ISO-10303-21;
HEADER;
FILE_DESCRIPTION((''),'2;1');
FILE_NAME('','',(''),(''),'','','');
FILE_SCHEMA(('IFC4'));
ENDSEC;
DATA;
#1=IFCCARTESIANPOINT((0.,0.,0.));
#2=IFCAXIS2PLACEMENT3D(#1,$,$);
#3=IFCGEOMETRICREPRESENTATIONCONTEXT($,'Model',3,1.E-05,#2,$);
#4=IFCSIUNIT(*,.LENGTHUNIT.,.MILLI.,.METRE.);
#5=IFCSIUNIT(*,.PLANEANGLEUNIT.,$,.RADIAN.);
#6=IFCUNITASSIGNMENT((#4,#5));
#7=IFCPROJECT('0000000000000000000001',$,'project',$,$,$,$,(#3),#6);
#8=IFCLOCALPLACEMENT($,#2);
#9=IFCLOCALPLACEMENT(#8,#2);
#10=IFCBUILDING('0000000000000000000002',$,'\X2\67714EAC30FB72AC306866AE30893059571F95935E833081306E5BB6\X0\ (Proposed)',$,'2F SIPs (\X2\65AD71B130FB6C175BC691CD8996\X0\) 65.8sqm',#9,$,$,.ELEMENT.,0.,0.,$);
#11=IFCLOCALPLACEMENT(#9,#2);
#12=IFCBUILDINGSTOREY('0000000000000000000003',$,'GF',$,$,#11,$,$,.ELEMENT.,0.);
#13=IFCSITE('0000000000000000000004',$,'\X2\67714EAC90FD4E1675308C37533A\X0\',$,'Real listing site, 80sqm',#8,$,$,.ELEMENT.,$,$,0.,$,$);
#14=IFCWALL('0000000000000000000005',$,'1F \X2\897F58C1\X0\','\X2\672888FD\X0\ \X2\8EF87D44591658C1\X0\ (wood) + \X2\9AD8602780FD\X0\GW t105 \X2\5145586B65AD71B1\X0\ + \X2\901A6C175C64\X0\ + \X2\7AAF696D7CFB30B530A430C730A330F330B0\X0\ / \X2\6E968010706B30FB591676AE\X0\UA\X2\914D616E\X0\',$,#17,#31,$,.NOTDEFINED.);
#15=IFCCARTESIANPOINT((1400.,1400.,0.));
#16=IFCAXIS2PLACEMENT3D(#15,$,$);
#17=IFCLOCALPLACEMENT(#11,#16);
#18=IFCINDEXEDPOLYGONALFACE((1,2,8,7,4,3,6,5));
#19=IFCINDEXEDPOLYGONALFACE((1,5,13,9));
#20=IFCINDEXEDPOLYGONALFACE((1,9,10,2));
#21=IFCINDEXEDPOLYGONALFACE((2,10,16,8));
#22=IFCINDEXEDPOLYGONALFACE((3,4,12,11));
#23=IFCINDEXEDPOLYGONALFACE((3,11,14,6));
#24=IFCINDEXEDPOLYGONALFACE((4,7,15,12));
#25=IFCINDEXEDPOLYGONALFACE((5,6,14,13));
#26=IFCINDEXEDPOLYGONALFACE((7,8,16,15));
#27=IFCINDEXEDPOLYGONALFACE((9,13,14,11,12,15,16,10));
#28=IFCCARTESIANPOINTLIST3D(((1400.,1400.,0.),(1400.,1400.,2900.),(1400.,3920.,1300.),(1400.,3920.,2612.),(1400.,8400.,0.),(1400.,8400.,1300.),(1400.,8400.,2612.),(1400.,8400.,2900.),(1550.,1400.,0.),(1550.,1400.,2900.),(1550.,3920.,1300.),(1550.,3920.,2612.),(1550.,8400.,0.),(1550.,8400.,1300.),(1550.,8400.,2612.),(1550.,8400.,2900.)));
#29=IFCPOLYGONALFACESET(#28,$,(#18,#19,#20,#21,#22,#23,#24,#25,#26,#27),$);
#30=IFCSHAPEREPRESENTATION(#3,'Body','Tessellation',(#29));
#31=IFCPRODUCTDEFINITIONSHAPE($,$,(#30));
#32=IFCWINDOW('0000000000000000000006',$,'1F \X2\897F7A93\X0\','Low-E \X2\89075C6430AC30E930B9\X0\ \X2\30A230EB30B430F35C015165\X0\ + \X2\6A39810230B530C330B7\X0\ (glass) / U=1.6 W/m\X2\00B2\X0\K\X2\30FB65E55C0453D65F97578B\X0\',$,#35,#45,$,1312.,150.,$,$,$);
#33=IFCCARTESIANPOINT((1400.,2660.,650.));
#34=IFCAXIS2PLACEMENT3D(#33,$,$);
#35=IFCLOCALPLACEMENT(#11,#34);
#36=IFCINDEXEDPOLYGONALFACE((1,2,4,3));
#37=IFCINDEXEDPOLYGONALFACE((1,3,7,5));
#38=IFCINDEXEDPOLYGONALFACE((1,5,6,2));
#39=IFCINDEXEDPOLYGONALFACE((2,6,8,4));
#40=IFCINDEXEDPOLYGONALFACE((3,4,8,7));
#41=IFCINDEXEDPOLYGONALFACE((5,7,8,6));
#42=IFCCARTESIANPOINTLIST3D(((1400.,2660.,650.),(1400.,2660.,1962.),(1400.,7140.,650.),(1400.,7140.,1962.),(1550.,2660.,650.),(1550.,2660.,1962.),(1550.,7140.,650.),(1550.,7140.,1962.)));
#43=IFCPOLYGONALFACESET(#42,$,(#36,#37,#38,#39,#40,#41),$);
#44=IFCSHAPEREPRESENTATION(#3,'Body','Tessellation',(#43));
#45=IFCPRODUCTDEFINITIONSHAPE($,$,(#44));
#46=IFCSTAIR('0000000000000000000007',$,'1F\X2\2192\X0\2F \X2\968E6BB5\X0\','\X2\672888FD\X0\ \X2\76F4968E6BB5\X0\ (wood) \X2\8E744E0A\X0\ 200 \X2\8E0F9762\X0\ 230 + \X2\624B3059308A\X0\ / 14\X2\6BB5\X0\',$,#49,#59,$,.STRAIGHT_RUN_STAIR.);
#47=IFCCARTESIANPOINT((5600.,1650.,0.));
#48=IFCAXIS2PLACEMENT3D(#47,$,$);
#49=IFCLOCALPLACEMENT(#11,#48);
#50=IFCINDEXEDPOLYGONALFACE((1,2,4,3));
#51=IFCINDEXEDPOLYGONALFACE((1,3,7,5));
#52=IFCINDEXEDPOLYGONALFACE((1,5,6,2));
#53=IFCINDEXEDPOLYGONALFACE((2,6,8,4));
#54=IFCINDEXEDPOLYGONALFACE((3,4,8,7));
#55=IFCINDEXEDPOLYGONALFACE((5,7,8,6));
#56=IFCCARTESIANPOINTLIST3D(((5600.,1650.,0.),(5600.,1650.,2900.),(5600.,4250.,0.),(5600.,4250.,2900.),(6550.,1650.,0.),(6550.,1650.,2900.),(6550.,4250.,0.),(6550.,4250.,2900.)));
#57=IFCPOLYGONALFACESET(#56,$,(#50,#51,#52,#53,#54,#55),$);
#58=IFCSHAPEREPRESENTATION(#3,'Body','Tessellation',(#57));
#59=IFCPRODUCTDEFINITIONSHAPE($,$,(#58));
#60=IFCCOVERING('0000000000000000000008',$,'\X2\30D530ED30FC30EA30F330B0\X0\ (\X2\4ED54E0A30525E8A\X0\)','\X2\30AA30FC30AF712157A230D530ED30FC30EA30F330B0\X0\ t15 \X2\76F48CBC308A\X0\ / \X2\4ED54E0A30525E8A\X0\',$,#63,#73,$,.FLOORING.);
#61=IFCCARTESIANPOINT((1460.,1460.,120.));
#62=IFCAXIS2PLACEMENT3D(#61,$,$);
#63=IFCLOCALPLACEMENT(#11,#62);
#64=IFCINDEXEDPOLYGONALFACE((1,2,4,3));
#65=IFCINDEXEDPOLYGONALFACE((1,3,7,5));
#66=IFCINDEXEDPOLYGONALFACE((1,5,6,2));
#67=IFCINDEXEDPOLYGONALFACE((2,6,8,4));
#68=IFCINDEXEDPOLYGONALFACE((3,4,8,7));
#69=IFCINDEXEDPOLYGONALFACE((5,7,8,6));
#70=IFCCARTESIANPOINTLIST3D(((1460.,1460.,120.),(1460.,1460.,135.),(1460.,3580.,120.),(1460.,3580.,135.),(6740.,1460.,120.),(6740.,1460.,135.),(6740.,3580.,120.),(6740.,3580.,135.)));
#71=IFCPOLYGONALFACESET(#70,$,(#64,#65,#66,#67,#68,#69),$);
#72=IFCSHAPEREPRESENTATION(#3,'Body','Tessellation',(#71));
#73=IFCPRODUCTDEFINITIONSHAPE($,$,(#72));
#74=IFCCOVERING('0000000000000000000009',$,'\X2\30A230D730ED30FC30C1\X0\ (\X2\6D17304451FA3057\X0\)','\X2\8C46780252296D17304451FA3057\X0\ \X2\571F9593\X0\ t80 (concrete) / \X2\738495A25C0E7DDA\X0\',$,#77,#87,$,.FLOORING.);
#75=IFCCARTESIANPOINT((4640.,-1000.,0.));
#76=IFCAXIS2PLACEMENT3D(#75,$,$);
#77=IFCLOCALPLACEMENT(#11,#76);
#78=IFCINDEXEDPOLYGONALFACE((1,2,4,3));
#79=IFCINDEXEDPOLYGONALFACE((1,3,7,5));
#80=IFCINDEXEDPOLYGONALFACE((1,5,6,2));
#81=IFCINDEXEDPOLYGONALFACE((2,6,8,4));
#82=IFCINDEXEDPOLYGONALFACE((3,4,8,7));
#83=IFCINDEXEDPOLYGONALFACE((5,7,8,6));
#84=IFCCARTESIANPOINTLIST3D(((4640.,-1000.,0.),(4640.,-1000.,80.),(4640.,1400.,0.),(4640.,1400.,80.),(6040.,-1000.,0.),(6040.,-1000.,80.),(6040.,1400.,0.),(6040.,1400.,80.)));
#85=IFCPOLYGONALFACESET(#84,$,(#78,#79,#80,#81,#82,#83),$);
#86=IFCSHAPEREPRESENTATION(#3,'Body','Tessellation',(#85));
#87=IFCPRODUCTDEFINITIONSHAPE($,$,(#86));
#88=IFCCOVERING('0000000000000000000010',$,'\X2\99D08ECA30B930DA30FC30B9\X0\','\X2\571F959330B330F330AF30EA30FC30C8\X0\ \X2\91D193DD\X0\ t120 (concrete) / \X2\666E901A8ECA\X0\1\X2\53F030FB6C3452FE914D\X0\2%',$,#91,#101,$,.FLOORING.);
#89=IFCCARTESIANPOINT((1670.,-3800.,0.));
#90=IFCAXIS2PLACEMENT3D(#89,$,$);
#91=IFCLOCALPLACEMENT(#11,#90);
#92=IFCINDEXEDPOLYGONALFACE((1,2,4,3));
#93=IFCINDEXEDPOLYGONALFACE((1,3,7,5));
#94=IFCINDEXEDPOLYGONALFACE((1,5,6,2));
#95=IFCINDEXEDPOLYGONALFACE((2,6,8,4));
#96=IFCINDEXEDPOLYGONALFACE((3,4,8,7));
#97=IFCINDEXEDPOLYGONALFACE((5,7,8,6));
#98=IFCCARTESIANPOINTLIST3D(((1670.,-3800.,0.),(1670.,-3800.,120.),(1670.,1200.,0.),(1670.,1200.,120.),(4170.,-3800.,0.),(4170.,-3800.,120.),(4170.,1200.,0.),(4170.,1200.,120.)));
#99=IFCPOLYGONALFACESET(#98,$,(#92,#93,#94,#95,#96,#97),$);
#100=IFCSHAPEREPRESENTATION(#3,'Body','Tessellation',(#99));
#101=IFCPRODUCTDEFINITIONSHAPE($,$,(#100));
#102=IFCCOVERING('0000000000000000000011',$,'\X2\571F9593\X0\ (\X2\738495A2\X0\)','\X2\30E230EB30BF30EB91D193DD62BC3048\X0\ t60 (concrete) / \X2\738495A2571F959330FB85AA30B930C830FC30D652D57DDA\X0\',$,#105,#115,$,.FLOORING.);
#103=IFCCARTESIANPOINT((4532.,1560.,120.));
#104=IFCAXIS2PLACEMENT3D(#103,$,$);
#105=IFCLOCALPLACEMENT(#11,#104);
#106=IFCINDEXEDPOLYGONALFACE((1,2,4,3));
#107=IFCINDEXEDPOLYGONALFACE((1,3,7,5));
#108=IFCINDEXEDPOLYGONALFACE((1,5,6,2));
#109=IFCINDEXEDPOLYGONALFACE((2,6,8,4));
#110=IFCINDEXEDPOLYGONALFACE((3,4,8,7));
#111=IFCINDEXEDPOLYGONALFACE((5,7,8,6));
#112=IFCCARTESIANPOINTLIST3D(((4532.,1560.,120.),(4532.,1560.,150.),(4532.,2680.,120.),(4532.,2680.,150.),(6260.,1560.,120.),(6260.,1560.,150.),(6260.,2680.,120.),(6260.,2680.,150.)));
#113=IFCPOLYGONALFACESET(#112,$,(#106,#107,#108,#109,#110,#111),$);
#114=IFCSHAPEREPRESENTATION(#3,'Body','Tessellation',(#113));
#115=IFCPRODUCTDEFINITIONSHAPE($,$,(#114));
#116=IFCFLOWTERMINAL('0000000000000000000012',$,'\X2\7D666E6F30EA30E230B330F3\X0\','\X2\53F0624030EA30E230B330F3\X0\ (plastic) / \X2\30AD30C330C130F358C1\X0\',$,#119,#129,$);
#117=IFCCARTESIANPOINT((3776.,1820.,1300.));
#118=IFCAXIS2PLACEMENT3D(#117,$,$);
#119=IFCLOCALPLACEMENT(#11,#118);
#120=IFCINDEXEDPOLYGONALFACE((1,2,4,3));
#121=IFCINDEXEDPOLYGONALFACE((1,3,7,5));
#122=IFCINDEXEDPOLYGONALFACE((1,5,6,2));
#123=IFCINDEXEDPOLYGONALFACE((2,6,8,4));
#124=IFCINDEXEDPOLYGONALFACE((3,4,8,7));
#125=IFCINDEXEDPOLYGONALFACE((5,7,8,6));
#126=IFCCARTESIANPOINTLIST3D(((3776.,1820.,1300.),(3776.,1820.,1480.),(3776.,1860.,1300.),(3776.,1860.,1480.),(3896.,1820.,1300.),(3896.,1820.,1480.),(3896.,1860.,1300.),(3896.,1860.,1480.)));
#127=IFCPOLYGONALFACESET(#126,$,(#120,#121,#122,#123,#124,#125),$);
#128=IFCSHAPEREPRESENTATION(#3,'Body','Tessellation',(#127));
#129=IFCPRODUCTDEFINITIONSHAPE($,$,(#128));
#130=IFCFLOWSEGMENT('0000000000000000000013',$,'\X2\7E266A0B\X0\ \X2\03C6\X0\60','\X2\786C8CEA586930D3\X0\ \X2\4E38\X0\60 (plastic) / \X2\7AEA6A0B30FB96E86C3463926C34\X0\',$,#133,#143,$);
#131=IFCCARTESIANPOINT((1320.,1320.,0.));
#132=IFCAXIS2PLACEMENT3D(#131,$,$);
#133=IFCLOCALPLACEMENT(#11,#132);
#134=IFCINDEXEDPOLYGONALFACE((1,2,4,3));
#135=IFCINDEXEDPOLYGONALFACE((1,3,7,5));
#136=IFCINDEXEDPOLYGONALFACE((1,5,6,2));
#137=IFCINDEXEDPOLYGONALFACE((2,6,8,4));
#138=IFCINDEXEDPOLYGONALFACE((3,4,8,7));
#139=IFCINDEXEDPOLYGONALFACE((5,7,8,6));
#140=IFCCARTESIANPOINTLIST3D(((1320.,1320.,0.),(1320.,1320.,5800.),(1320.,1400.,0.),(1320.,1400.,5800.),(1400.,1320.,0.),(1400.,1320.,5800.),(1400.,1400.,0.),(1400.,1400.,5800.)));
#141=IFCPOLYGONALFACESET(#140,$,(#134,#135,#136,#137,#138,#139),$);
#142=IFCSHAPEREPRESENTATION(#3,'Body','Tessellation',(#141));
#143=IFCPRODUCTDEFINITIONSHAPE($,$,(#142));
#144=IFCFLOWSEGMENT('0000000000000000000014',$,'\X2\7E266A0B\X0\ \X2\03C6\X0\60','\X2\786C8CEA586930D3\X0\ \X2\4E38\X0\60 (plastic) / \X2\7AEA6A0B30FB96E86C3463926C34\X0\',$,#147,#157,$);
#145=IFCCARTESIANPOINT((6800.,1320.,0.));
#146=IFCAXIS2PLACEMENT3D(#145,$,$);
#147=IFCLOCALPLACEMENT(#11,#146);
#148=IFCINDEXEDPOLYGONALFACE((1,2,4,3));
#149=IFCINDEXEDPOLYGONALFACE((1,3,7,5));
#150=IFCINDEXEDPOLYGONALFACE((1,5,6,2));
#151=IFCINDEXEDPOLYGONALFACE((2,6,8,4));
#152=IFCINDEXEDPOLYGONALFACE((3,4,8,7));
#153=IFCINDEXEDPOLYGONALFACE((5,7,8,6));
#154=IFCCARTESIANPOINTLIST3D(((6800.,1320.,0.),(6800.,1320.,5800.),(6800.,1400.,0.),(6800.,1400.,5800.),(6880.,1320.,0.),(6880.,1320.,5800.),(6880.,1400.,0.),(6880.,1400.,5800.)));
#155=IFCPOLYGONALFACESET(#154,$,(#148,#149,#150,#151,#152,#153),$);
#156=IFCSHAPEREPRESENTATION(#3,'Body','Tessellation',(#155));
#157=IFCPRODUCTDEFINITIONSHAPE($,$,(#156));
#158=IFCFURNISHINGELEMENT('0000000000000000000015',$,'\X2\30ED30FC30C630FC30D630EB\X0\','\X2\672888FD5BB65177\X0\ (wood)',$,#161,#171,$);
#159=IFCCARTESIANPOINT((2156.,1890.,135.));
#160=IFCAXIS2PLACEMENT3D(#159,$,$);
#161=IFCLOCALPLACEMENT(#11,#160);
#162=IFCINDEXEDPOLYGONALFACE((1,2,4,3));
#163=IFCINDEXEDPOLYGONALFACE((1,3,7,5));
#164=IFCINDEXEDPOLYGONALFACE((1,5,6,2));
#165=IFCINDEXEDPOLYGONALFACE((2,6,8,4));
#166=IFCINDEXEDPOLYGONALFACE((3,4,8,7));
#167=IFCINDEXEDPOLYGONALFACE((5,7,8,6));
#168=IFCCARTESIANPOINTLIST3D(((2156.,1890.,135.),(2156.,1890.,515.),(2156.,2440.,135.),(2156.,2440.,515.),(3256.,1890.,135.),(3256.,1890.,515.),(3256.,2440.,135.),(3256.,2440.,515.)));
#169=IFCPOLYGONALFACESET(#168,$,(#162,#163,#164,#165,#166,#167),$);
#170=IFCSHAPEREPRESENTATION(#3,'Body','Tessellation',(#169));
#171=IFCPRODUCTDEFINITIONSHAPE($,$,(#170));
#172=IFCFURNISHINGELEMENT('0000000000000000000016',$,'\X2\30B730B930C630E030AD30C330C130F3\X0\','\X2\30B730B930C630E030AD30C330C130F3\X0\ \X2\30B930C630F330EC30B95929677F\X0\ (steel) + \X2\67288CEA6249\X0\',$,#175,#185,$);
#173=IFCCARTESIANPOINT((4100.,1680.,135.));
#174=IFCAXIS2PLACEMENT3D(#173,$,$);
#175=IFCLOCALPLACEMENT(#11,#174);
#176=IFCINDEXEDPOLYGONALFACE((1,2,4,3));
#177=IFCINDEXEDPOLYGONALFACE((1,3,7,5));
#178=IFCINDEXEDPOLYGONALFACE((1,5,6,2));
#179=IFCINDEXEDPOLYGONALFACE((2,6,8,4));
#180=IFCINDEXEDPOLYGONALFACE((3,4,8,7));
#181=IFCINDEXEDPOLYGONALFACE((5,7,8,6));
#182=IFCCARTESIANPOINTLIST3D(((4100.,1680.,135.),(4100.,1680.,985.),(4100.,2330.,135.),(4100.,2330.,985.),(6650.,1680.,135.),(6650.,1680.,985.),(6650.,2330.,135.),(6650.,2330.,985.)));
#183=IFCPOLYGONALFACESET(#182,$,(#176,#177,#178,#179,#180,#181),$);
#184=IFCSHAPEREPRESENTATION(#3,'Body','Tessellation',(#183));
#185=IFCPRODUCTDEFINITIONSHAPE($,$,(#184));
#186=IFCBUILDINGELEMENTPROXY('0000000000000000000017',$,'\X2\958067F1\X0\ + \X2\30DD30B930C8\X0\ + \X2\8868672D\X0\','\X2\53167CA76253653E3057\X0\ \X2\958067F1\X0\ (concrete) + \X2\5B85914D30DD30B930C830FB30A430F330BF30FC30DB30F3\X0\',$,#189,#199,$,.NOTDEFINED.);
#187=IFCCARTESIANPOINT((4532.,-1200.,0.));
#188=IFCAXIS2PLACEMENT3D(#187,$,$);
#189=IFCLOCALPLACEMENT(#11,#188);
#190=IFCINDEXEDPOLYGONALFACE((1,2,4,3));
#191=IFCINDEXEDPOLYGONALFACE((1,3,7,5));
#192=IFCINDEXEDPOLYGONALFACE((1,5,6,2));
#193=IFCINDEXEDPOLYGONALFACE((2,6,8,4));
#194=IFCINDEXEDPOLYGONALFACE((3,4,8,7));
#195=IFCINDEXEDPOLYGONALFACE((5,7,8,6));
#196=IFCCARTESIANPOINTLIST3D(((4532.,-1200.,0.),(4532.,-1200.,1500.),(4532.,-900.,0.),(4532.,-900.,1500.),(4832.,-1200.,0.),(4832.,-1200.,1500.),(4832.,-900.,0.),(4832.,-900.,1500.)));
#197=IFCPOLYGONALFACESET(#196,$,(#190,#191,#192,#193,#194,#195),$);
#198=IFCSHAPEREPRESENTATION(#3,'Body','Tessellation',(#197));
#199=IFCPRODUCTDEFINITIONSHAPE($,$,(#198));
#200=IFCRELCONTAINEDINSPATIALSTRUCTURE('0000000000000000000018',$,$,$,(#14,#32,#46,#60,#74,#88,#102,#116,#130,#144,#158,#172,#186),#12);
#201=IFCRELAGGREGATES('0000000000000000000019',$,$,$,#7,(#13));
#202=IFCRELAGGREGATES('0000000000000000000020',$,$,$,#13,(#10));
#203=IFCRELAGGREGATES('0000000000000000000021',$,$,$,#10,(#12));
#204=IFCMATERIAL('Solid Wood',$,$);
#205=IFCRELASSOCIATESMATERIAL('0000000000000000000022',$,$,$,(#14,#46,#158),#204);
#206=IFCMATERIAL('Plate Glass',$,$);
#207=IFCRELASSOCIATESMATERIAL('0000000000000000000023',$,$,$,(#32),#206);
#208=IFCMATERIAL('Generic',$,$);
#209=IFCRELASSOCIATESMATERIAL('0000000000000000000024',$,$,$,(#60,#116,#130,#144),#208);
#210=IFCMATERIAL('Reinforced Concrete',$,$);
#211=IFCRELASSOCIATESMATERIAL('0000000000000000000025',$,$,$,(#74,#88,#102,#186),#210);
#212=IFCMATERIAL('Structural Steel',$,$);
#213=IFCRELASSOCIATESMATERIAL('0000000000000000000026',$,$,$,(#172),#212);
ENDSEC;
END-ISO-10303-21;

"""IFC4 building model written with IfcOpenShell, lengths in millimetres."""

from ifc_helpers import new_model, si_unit, frame, frame_2d, origin, place, context, project, spatial, rectangle, extrude, material, element, fill, save


model = new_model("IFC4")

# Units and contexts
model_context = context("Model", 3, precision=1e-05, world=origin())
ifc_project = project(units=[si_unit("LENGTHUNIT", "METRE", prefix="MILLI"), si_unit("PLANEANGLEUNIT", "RADIAN")], contexts=[model_context])

# Site, building, storey
site_placement = place(None, origin())
site = spatial("IfcSite", under=ifc_project, at=site_placement, Name="東京都世田谷区", ObjectType="Real listing site, 80sqm", CompositionType="ELEMENT", RefElevation=0.0)
building_placement = place(site_placement, origin())
building = spatial("IfcBuilding", under=site, at=building_placement, Name="東京・犬と暮らす土間広めの家 (Proposed)", ObjectType="2F SIPs (断熱・気密重視) 65.8sqm", CompositionType="ELEMENT", ElevationOfRefHeight=0.0, ElevationOfTerrain=0.0)
storey_placement = place(building_placement, origin())
storey = spatial("IfcBuildingStorey", under=building, at=storey_placement, Name="GF", CompositionType="ELEMENT", Elevation=0.0)

# Shared definitions
ifc_material_1 = material(Name="Solid Wood")

# Shared definitions
ifc_material_2 = material(Name="Reinforced Concrete")

# Shared definitions
ifc_material_3 = material(Name="Plate Glass")

# Wall, opening, window
wall_1_placement = place(storey_placement, frame((1400.0, 1400.0, 0.0)))
wall_1 = element("IfcWall", 1, at=wall_1_placement, inside=storey, material=ifc_material_1, Name="1F 西壁", Description="木製 軸組外壁 (wood) + 高性能GW t105 充填断熱 + 通気層 + 窯業系サイディング / 準耐火・外皮UA配慮", PredefinedType="NOTDEFINED", context=model_context, shape_type="SweptSolid", body=[
    extrude(rectangle(XDim=150.0, YDim=7000.0, at=frame_2d((75.0, 3500.0))), frame((1400.0, 1400.0, 0.0)), (0.0, 0.0, 1.0), 2900.0),
])
opening_1_placement = place(storey_placement, frame((1400.0, 2660.0, 650.0)))
opening_1 = element("IfcOpeningElement", 2, at=opening_1_placement, cuts=wall_1, PredefinedType="NOTDEFINED", context=model_context, shape_type="SweptSolid", body=[
    extrude(rectangle(XDim=150.0, YDim=4480.0, at=frame_2d((75.0, 2240.0))), frame((1400.0, 2660.0, 650.0)), (0.0, 0.0, 1.0), 1312.0),
])
window_1_placement = place(storey_placement, frame((1400.0, 2660.0, 650.0)))
window_1 = element("IfcWindow", 3, at=window_1_placement, inside=storey, material=ifc_material_3, Name="1F 西窓", Description="Low-E 複層ガラス アルゴン封入 + 樹脂サッシ (glass) / U=1.6 W/m²K・日射取得型", OverallHeight=1312.0, OverallWidth=150.0, context=model_context, shape_type="SweptSolid", body=[
    extrude(rectangle(XDim=150.0, YDim=4480.0, at=frame_2d((75.0, 2240.0))), frame((1400.0, 2660.0, 650.0)), (0.0, 0.0, 1.0), 1312.0),
])
fill(opening_1, window_1)

# Stair
stair_placement = place(storey_placement, frame((5600.0, 1650.0, 0.0)))
element("IfcStair", 4, at=stair_placement, inside=storey, material=ifc_material_1, Name="1F→2F 階段", Description="木製 直階段 (wood) 蹴上 200 踏面 230 + 手すり / 14段", PredefinedType="STRAIGHT_RUN_STAIR", context=model_context, shape_type="SweptSolid", body=[
    extrude(rectangle(XDim=950.0, YDim=2600.0, at=frame_2d((475.0, 1300.0))), frame((5600.0, 1650.0, 0.0)), (0.0, 0.0, 1.0), 2900.0),
])

# Coverings
ifc_material_4 = material(Name="Generic")
covering_1_placement = place(storey_placement, frame((1460.0, 1460.0, 120.0)))
element("IfcCovering", 5, at=covering_1_placement, inside=storey, material=ifc_material_4, Name="フローリング (仕上げ床)", Description="オーク無垢フローリング t15 直貼り / 仕上げ床", PredefinedType="FLOORING", context=model_context, shape_type="SweptSolid", body=[
    extrude(rectangle(XDim=5280.0, YDim=2120.0, at=frame_2d((2640.0, 1060.0))), frame((1460.0, 1460.0, 120.0)), (0.0, 0.0, 1.0), 15.0),
])
covering_2_placement = place(storey_placement, frame((4640.0, -1000.0, 0.0)))
element("IfcCovering", 6, at=covering_2_placement, inside=storey, material=ifc_material_2, Name="アプローチ (洗い出し)", Description="豆砂利洗い出し 土間 t80 (concrete) / 玄関導線", PredefinedType="FLOORING", context=model_context, shape_type="SweptSolid", body=[
    extrude(rectangle(XDim=1400.0, YDim=2400.0, at=frame_2d((700.0, 1200.0))), frame((4640.0, -1000.0, 0.0)), (0.0, 0.0, 1.0), 80.0),
])
covering_3_placement = place(storey_placement, frame((1670.0, -3800.0, 0.0)))
element("IfcCovering", 7, at=covering_3_placement, inside=storey, material=ifc_material_2, Name="駐車スペース", Description="土間コンクリート 金鏝 t120 (concrete) / 普通車1台・水勾配2%", PredefinedType="FLOORING", context=model_context, shape_type="SweptSolid", body=[
    extrude(rectangle(XDim=2500.0, YDim=5000.0, at=frame_2d((1250.0, 2500.0))), frame((1670.0, -3800.0, 0.0)), (0.0, 0.0, 1.0), 120.0),
])
covering_4_placement = place(storey_placement, frame((4532.0, 1560.0, 120.0)))
element("IfcCovering", 8, at=covering_4_placement, inside=storey, material=ifc_material_2, Name="土間 (玄関)", Description="モルタル金鏝押え t60 (concrete) / 玄関土間・薪ストーブ動線", PredefinedType="FLOORING", context=model_context, shape_type="SweptSolid", body=[
    extrude(rectangle(XDim=1728.0, YDim=1120.0, at=frame_2d((864.0, 560.0))), frame((4532.0, 1560.0, 120.0)), (0.0, 0.0, 1.0), 30.0),
])

# Flow terminal
flow_terminal_placement = place(storey_placement, frame((3776.0, 1820.0, 1300.0)))
element("IfcFlowTerminal", 9, at=flow_terminal_placement, inside=storey, material=ifc_material_4, Name="給湯リモコン", Description="台所リモコン (plastic) / キッチン壁", context=model_context, shape_type="SweptSolid", body=[
    extrude(rectangle(XDim=120.0, YDim=40.0, at=frame_2d((60.0, 20.0))), frame((3776.0, 1820.0, 1300.0)), (0.0, 0.0, 1.0), 180.0),
])

# Flow segments
flow_segment_1_placement = place(storey_placement, frame((1320.0, 1320.0, 0.0)))
element("IfcFlowSegment", 10, at=flow_segment_1_placement, inside=storey, material=ifc_material_4, Name="縦樋 φ60", Description="硬質塩ビ 丸60 (plastic) / 竪樋・雨水排水", context=model_context, shape_type="SweptSolid", body=[
    extrude(rectangle(XDim=80.0, YDim=80.0, at=frame_2d((40.0, 40.0))), frame((1320.0, 1320.0, 0.0)), (0.0, 0.0, 1.0), 5800.0),
])
flow_segment_2_placement = place(storey_placement, frame((6800.0, 1320.0, 0.0)))
element("IfcFlowSegment", 11, at=flow_segment_2_placement, inside=storey, material=ifc_material_4, Name="縦樋 φ60", Description="硬質塩ビ 丸60 (plastic) / 竪樋・雨水排水", context=model_context, shape_type="SweptSolid", body=[
    extrude(rectangle(XDim=80.0, YDim=80.0, at=frame_2d((40.0, 40.0))), frame((6800.0, 1320.0, 0.0)), (0.0, 0.0, 1.0), 5800.0),
])

# Furnishing elements
furnishing_1_placement = place(storey_placement, frame((2156.0, 1890.0, 135.0)))
element("IfcFurnishingElement", 12, at=furnishing_1_placement, inside=storey, material=ifc_material_1, Name="ローテーブル", Description="木製家具 (wood)", context=model_context, shape_type="SweptSolid", body=[
    extrude(rectangle(XDim=1100.0, YDim=550.0, at=frame_2d((550.0, 275.0))), frame((2156.0, 1890.0, 135.0)), (0.0, 0.0, 1.0), 380.0),
])
ifc_material_5 = material(Name="Structural Steel")
furnishing_2_placement = place(storey_placement, frame((4100.0, 1680.0, 135.0)))
element("IfcFurnishingElement", 13, at=furnishing_2_placement, inside=storey, material=ifc_material_5, Name="システムキッチン", Description="システムキッチン ステンレス天板 (steel) + 木質扉", context=model_context, shape_type="SweptSolid", body=[
    extrude(rectangle(XDim=2550.0, YDim=650.0, at=frame_2d((1275.0, 325.0))), frame((4100.0, 1680.0, 135.0)), (0.0, 0.0, 1.0), 850.0),
])

# Building element proxy
proxy_placement = place(storey_placement, frame((4532.0, -1200.0, 0.0)))
element("IfcBuildingElementProxy", 14, at=proxy_placement, inside=storey, material=ifc_material_2, Name="門柱 + ポスト + 表札", Description="化粧打放し 門柱 (concrete) + 宅配ポスト・インターホン", PredefinedType="NOTDEFINED", context=model_context, shape_type="SweptSolid", body=[
    extrude(rectangle(XDim=300.0, YDim=300.0, at=frame_2d((150.0, 150.0))), frame((4532.0, -1200.0, 0.0)), (0.0, 0.0, 1.0), 1500.0),
])

save(model, "model.ifc")
